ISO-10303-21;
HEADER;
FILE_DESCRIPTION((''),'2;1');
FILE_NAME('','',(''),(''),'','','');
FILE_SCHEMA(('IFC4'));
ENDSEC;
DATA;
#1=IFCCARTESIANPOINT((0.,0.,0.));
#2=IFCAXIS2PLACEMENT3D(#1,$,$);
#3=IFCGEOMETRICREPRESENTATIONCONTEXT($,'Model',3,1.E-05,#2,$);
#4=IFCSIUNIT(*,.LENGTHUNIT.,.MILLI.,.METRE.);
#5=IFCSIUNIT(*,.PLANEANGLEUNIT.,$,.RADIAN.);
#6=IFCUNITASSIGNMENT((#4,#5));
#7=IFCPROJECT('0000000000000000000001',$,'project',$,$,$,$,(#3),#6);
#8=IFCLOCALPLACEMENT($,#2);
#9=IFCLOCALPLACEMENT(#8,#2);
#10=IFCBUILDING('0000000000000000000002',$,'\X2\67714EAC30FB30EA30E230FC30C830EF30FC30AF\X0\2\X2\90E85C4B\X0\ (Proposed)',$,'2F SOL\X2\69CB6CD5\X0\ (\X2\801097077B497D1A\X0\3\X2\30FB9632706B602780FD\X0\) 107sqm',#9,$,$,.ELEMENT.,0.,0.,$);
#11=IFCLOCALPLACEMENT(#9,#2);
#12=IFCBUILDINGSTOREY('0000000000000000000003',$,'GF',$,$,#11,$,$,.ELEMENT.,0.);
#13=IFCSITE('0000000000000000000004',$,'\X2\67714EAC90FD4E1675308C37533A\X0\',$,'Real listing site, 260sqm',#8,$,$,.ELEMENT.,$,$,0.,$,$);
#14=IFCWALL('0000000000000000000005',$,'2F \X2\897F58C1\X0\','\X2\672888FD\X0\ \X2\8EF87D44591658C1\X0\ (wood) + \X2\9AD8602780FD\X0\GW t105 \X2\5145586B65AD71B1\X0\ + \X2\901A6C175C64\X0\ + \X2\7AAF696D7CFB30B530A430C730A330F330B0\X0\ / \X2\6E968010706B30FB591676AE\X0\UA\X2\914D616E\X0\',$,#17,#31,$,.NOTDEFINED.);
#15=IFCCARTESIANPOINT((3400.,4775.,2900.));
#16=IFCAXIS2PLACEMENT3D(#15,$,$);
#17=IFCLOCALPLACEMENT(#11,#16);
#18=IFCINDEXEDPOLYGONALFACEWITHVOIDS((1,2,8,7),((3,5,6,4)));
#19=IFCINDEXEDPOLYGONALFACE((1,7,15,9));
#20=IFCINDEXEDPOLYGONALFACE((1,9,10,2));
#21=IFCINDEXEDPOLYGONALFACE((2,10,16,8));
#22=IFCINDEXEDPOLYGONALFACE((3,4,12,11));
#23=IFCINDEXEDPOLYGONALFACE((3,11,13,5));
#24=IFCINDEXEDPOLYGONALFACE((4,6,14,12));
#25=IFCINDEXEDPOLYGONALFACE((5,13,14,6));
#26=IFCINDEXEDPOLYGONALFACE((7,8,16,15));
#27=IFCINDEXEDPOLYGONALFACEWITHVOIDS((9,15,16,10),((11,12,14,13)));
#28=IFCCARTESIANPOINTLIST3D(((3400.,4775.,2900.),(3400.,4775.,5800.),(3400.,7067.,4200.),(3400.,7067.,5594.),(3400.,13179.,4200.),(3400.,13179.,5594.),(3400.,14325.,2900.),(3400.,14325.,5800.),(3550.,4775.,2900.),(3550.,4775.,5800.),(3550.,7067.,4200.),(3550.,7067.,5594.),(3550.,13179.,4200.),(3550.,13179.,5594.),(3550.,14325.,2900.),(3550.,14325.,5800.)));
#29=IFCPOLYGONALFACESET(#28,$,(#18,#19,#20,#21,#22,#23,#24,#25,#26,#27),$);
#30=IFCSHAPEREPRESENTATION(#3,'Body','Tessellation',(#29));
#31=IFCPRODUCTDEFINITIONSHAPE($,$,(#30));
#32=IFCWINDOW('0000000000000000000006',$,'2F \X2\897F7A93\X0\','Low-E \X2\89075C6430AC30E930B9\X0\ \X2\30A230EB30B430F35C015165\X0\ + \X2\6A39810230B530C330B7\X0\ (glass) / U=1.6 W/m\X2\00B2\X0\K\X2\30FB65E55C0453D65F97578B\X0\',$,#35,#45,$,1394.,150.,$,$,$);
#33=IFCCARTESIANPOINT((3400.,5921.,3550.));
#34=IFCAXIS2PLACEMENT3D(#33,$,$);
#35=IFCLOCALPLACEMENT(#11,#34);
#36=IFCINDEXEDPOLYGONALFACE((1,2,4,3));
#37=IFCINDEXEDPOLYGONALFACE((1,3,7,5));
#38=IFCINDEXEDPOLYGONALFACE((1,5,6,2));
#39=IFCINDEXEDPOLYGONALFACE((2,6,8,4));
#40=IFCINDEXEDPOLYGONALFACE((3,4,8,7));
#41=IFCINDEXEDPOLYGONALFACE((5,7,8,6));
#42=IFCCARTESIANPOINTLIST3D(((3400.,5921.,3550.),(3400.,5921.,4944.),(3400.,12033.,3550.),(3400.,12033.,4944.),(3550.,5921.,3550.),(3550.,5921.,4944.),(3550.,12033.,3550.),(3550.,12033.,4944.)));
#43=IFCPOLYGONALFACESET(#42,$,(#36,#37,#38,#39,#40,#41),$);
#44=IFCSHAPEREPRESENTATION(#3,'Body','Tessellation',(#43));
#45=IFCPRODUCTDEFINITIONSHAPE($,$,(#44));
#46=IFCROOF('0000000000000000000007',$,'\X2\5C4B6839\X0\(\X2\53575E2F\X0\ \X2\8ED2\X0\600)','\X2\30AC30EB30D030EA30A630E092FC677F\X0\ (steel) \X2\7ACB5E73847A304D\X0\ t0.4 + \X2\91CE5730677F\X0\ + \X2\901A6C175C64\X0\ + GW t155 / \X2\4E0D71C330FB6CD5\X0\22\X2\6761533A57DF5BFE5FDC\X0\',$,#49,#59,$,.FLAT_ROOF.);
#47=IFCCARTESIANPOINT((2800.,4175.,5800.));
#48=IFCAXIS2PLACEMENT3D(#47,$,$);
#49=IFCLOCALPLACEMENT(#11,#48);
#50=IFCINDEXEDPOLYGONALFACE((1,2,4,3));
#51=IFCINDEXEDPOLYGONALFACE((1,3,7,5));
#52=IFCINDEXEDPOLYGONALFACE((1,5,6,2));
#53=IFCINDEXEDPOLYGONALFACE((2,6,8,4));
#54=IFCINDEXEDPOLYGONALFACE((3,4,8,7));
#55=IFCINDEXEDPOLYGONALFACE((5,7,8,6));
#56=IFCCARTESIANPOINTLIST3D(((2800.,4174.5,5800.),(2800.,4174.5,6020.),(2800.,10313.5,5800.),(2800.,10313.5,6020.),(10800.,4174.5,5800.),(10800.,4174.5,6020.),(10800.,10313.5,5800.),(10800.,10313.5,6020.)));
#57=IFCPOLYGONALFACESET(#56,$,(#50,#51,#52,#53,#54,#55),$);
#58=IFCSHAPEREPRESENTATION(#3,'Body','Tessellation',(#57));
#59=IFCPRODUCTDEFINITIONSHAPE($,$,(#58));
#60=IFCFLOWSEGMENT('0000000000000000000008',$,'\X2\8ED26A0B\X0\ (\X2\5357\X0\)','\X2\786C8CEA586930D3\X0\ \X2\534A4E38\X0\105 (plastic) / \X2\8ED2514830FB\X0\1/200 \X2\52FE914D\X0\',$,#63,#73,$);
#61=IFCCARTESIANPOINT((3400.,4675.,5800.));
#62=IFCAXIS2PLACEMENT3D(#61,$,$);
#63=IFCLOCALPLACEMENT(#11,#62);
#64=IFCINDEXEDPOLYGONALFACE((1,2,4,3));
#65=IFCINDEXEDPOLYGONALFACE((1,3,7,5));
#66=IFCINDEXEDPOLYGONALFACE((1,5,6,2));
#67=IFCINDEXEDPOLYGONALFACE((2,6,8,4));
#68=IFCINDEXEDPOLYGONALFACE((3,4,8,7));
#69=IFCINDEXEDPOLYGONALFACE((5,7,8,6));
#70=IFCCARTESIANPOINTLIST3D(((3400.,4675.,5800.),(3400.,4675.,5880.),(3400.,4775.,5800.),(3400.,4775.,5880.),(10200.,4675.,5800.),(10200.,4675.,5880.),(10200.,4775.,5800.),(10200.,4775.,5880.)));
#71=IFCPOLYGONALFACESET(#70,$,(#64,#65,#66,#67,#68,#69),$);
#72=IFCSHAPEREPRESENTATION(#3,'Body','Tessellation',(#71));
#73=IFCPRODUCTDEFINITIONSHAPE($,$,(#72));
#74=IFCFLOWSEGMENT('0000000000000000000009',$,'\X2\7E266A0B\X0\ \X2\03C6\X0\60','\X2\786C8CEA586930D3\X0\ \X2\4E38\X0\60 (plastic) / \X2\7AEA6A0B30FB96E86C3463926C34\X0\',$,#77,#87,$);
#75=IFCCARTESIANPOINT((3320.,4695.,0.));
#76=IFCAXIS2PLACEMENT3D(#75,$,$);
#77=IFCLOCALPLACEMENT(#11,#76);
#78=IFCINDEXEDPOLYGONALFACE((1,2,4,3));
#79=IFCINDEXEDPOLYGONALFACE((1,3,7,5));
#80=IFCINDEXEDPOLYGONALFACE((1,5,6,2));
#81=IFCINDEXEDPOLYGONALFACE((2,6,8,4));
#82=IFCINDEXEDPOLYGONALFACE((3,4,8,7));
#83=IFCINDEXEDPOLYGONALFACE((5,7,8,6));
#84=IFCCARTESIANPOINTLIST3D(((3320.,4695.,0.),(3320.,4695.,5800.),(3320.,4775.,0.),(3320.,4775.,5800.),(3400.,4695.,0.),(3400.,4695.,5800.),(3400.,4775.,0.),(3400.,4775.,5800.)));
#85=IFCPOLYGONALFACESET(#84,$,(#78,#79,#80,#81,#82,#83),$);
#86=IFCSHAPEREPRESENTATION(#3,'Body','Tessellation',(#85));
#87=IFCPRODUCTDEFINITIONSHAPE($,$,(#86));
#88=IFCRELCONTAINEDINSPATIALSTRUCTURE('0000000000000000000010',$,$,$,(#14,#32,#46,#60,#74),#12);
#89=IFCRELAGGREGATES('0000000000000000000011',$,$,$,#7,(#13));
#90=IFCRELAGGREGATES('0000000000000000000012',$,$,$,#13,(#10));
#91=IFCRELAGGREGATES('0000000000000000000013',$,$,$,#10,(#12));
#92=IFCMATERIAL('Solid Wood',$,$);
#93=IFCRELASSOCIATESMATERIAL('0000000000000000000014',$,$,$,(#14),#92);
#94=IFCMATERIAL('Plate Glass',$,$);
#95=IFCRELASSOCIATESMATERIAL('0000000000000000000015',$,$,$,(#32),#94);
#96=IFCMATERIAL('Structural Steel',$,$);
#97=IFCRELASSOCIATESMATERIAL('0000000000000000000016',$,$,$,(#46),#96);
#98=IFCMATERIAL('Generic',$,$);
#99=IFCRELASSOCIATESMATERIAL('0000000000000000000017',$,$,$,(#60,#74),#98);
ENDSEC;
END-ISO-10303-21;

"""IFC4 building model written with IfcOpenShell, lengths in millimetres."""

from ifc_helpers import new_model, si_unit, frame, frame_2d, origin, place, context, project, spatial, rectangle, extrude, material, element, fill, save


model = new_model("IFC4")

# Units and contexts
model_context = context("Model", 3, precision=1e-05, world=origin())
ifc_project = project(units=[si_unit("LENGTHUNIT", "METRE", prefix="MILLI"), si_unit("PLANEANGLEUNIT", "RADIAN")], contexts=[model_context])

# Site, building, storey
site_placement = place(None, origin())
site = spatial("IfcSite", under=ifc_project, at=site_placement, Name="東京都世田谷区", ObjectType="Real listing site, 260sqm", CompositionType="ELEMENT", RefElevation=0.0)
building_placement = place(site_placement, origin())
building = spatial("IfcBuilding", under=site, at=building_placement, Name="東京・リモートワーク2部屋 (Proposed)", ObjectType="2F SOL構法 (耐震等級3・防火性能) 107sqm", CompositionType="ELEMENT", ElevationOfRefHeight=0.0, ElevationOfTerrain=0.0)
storey_placement = place(building_placement, origin())
storey = spatial("IfcBuildingStorey", under=building, at=storey_placement, Name="GF", CompositionType="ELEMENT", Elevation=0.0)

# Shared definitions
ifc_material_1 = material(Name="Solid Wood")

# Shared definitions
ifc_material_2 = material(Name="Plate Glass")

# Wall, opening, window
wall_1_placement = place(storey_placement, frame((3400.0, 4775.0, 2900.0)))
wall_1 = element("IfcWall", 1, at=wall_1_placement, inside=storey, material=ifc_material_1, Name="2F 西壁", Description="木製 軸組外壁 (wood) + 高性能GW t105 充填断熱 + 通気層 + 窯業系サイディング / 準耐火・外皮UA配慮", PredefinedType="NOTDEFINED", context=model_context, shape_type="SweptSolid", body=[
    extrude(rectangle(XDim=150.0, YDim=9550.0, at=frame_2d((75.0, 4775.0))), frame((3400.0, 4775.0, 2900.0)), (0.0, 0.0, 1.0), 2900.0),
])
opening_1_placement = place(storey_placement, frame((3400.0, 5921.0, 3550.0)))
opening_1 = element("IfcOpeningElement", 2, at=opening_1_placement, cuts=wall_1, PredefinedType="NOTDEFINED", context=model_context, shape_type="SweptSolid", body=[
    extrude(rectangle(XDim=150.0, YDim=6112.0, at=frame_2d((75.0, 3056.0))), frame((3400.0, 5921.0, 3550.0)), (0.0, 0.0, 1.0), 1394.0),
])
window_1_placement = place(storey_placement, frame((3400.0, 5921.0, 3550.0)))
window_1 = element("IfcWindow", 3, at=window_1_placement, inside=storey, material=ifc_material_2, Name="2F 西窓", Description="Low-E 複層ガラス アルゴン封入 + 樹脂サッシ (glass) / U=1.6 W/m²K・日射取得型", OverallHeight=1394.0, OverallWidth=150.0, context=model_context, shape_type="SweptSolid", body=[
    extrude(rectangle(XDim=150.0, YDim=6112.0, at=frame_2d((75.0, 3056.0))), frame((3400.0, 5921.0, 3550.0)), (0.0, 0.0, 1.0), 1394.0),
])
fill(opening_1, window_1)

# Roof
ifc_material_3 = material(Name="Structural Steel")
for number, where, name in (
    (4, (2800.0, 4175.0, 5800.0), "屋根(南帯 軒600)"),
):
    element("IfcRoof", number, at=place(storey_placement, frame(where)), inside=storey, material=ifc_material_3, Name=name, Description="ガルバリウム鋼板 (steel) 立平葺き t0.4 + 野地板 + 通気層 + GW t155 / 不燃・法22条区域対応", PredefinedType="FLAT_ROOF", context=model_context, shape_type="SweptSolid", body=[
        extrude(rectangle(XDim=8000.0, YDim=6139.0, at=frame_2d((4000.0, 3069.0))), frame((2800.0, 4175.0, 5800.0)), (0.0, 0.0, 1.0), 220.0),
    ])

# Flow segments
ifc_material_4 = material(Name="Generic")
flow_segment_1_placement = place(storey_placement, frame((3400.0, 4675.0, 5800.0)))
element("IfcFlowSegment", 5, at=flow_segment_1_placement, inside=storey, material=ifc_material_4, Name="軒樋 (南)", Description="硬質塩ビ 半丸105 (plastic) / 軒先・1/200 勾配", context=model_context, shape_type="SweptSolid", body=[
    extrude(rectangle(XDim=6800.0, YDim=100.0, at=frame_2d((3400.0, 50.0))), frame((3400.0, 4675.0, 5800.0)), (0.0, 0.0, 1.0), 80.0),
])
flow_segment_2_placement = place(storey_placement, frame((3320.0, 4695.0, 0.0)))
element("IfcFlowSegment", 6, at=flow_segment_2_placement, inside=storey, material=ifc_material_4, Name="縦樋 φ60", Description="硬質塩ビ 丸60 (plastic) / 竪樋・雨水排水", context=model_context, shape_type="SweptSolid", body=[
    extrude(rectangle(XDim=80.0, YDim=80.0, at=frame_2d((40.0, 40.0))), frame((3320.0, 4695.0, 0.0)), (0.0, 0.0, 1.0), 5800.0),
])

save(model, "model.ifc")
